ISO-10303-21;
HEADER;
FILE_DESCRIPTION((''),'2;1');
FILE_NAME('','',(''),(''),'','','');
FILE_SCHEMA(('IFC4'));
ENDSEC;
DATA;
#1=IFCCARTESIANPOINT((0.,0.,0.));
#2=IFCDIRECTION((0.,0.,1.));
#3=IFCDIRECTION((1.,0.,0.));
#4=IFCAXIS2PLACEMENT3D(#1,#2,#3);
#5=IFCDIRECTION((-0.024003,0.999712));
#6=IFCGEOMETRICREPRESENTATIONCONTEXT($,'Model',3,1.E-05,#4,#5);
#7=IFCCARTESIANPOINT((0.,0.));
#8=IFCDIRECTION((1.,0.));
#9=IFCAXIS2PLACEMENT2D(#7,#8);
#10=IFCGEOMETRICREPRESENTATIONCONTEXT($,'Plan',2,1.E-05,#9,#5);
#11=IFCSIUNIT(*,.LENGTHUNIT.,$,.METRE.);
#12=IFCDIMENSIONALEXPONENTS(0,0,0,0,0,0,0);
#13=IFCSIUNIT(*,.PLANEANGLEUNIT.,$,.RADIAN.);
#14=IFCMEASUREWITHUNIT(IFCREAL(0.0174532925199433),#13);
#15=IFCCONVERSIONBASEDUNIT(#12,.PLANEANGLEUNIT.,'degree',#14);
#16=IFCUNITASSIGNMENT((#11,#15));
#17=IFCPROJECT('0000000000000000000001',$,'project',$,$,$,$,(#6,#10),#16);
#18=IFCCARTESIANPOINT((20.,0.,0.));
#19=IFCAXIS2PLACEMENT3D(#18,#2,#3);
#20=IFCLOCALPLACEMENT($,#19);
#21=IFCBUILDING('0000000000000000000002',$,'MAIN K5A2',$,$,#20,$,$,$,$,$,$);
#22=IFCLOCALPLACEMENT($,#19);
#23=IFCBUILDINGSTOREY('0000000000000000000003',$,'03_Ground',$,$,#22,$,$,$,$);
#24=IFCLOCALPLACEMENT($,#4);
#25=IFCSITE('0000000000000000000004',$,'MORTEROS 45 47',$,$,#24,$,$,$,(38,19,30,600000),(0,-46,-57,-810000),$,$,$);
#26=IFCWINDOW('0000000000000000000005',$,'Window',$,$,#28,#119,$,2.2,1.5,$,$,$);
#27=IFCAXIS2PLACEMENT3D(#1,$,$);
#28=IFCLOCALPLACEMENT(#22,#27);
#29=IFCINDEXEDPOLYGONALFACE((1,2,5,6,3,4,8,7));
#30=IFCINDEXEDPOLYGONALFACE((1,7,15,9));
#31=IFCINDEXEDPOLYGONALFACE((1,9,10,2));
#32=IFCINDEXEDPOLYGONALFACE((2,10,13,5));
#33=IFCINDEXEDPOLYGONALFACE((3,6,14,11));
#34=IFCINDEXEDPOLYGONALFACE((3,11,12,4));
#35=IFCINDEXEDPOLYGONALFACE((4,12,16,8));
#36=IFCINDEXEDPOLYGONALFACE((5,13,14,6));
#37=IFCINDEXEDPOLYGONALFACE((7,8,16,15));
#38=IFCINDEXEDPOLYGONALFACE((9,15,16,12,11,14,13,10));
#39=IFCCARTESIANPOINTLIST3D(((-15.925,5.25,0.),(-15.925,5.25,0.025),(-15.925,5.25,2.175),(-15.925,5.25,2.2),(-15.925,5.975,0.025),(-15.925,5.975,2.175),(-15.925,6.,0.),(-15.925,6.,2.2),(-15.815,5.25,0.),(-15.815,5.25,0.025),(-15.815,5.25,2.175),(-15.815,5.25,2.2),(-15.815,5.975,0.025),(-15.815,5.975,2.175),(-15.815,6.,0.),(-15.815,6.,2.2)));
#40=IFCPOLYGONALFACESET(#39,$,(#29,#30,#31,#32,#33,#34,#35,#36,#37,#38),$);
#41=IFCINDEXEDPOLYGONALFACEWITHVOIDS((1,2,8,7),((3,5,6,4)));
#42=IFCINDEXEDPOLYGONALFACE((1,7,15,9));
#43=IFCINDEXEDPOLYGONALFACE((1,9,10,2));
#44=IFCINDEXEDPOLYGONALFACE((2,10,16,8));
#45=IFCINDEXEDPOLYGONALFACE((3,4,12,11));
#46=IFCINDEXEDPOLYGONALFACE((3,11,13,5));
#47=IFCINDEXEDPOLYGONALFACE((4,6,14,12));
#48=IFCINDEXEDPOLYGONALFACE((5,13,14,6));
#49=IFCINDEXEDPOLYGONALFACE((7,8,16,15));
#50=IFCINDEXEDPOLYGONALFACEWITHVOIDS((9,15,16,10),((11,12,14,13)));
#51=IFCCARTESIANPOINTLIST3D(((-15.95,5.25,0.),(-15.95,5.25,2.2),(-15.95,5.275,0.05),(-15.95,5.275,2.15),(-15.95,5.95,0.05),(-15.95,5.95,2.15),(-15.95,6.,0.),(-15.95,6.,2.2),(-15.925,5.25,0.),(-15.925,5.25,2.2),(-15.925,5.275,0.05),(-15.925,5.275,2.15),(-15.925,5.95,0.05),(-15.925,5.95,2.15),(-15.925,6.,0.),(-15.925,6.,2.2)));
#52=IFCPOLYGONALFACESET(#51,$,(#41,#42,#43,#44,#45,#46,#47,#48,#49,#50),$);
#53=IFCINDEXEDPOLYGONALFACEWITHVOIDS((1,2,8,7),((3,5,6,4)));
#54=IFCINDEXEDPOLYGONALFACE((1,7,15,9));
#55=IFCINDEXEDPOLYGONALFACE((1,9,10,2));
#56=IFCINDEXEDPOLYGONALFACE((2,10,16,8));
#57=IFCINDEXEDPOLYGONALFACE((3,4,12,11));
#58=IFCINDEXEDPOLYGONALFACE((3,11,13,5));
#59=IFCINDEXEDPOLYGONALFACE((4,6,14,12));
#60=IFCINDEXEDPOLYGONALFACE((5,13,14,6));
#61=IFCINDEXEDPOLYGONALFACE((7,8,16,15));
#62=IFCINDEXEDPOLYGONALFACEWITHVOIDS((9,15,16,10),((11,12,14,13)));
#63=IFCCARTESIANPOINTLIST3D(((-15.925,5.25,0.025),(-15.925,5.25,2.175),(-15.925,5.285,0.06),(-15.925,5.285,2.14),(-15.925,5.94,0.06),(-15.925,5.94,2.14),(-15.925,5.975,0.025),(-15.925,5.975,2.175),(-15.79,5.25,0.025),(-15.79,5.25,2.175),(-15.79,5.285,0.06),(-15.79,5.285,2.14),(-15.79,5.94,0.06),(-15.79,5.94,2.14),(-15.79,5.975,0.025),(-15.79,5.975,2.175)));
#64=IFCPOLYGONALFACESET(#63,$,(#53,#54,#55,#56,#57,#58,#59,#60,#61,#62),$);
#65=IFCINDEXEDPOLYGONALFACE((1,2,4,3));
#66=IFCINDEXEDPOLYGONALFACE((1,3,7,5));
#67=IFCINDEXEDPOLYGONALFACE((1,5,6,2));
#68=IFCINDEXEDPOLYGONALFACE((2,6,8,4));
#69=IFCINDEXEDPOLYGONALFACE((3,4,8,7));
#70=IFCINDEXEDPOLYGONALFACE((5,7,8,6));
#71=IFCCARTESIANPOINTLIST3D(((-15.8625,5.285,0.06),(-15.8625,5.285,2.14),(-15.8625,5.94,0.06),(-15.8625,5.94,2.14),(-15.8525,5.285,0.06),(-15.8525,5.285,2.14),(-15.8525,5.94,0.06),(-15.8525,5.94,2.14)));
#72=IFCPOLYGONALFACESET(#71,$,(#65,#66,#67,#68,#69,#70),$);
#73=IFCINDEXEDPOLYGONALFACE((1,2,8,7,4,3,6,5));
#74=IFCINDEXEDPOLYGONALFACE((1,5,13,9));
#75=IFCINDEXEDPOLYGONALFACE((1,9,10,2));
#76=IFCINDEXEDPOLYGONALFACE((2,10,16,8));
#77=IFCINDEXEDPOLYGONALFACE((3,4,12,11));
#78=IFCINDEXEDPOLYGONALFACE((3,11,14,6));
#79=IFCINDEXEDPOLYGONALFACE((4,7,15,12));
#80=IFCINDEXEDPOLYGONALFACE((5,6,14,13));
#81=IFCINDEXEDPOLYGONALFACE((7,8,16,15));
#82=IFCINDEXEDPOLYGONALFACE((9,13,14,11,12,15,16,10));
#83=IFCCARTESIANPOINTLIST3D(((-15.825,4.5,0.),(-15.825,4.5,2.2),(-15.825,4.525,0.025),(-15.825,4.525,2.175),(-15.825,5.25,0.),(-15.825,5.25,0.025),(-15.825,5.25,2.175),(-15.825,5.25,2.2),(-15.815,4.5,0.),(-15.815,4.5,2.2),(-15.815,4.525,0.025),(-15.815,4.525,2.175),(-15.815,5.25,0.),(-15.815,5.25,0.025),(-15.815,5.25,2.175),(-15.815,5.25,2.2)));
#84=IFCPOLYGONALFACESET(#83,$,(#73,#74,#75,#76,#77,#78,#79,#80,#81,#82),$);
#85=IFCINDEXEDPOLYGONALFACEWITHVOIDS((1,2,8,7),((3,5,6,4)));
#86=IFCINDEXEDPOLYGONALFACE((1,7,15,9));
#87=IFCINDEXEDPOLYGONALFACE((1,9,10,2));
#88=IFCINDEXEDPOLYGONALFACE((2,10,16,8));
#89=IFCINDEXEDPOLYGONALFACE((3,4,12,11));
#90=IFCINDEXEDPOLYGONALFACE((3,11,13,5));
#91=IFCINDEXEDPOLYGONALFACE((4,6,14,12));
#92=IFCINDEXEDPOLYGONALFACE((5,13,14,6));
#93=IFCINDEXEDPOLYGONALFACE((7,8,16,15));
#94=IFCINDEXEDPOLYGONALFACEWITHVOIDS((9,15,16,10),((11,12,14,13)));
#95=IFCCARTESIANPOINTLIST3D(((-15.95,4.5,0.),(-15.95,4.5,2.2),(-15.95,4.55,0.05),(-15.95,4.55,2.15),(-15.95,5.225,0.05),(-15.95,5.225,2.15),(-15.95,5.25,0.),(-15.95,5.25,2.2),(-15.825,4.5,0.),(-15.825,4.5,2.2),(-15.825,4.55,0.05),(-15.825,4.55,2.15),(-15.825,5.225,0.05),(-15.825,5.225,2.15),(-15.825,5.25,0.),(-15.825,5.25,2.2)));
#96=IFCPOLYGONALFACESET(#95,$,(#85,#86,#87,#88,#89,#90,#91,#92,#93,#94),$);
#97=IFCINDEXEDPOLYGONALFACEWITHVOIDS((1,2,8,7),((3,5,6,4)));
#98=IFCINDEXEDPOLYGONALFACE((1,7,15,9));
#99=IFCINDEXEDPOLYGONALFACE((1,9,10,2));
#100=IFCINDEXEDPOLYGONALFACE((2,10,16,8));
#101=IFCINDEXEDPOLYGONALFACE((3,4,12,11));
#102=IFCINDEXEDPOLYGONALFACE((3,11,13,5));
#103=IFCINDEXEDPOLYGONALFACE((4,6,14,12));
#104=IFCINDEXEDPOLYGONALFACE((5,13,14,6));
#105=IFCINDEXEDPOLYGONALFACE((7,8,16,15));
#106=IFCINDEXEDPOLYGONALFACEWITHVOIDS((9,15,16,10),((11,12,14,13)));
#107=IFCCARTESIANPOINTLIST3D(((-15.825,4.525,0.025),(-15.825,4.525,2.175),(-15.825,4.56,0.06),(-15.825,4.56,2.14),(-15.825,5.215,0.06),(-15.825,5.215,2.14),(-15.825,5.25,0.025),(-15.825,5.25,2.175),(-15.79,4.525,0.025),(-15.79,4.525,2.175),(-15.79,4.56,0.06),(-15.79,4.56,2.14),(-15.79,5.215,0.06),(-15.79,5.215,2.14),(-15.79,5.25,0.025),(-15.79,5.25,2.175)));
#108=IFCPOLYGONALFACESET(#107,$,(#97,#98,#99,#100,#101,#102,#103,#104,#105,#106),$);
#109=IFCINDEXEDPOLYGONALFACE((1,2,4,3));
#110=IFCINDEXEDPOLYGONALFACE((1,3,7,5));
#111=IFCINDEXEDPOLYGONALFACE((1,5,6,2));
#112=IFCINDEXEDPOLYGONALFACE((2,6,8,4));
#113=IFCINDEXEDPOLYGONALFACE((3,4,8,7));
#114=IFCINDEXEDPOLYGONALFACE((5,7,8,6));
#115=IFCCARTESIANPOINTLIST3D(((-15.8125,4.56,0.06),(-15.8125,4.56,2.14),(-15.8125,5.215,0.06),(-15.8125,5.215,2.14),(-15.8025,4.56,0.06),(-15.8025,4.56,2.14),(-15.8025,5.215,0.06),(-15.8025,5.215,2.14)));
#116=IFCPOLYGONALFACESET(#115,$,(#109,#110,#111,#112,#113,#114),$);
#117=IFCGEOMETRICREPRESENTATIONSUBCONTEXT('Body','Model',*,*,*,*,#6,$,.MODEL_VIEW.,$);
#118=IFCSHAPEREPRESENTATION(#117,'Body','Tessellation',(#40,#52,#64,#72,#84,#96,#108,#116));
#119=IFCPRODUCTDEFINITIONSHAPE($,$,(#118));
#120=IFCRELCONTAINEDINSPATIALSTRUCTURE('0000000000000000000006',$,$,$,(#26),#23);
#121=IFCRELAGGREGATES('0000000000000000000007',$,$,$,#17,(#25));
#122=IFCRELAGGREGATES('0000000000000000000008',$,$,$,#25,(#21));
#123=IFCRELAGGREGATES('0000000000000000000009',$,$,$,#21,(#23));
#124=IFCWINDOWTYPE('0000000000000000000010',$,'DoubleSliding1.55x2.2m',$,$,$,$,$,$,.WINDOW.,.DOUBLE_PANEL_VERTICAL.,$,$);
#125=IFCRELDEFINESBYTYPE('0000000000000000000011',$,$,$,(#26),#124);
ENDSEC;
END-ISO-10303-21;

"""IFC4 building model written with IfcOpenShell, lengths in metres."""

from ifc_helpers import new_model, entity, si_unit, converted_unit, direction, frame, origin_with_axes, origin_2d_with_axis, place, context, subcontext, project, spatial, line, indexed_curve, outline, extrude, shape, source, transform, mapped, type_object, element, save


model = new_model("IFC4")

# Units and contexts
model_context = context("Model", 3, precision=1e-05, world=origin_with_axes(), true_north=direction((-0.024003, 0.999712)))
plan_context = context("Plan", 2, precision=1e-05, world=origin_2d_with_axis(), true_north=direction((-0.024003, 0.999712)))
body_context_1 = subcontext(model_context, "Body", "Model", "MODEL_VIEW")
body_context_2 = subcontext(plan_context, "Body", "Plan", "PLAN_VIEW")
ifc_project = project(units=[si_unit("LENGTHUNIT", "METRE"), converted_unit("PLANEANGLEUNIT", "degree", entity("IfcReal", 0.0174532925199433), si_unit("PLANEANGLEUNIT", "RADIAN"), dimensions=[0, 0, 0, 0, 0, 0, 0])], contexts=[model_context, plan_context])

# Site, building, storey
site_placement = place(None, origin_with_axes())
site = spatial("IfcSite", under=ifc_project, at=site_placement, Name="MORTEROS 45 47", RefLatitude=(38, 19, 30, 600000), RefLongitude=(0, -46, -57, -810000))
building_placement = place(None, frame((20.0, 0.0, 0.0), z_axis=(0.0, 0.0, 1.0), x_axis=(1.0, 0.0, 0.0)))
building = spatial("IfcBuilding", under=site, at=building_placement, Name="MAIN K5A2")
storey_placement = place(None, frame((20.0, 0.0, 0.0), z_axis=(0.0, 0.0, 1.0), x_axis=(1.0, 0.0, 0.0)))
storey = spatial("IfcBuildingStorey", under=building, at=storey_placement, Name="03_Ground")

# Window
window_type = type_object("IfcWindowType", Name="DoubleSliding1.55x2.2m", PartitioningType="DOUBLE_PANEL_VERTICAL", PredefinedType="WINDOW")
shared_shape_1 = source(origin_with_axes(), body_context_1, "Body", "SolidModel", [
    extrude(outline(indexed_curve([(0.75, 0.0), (0.0, 0.0), (0.0, 2.2), (0.75, 2.2), (0.75, 2.175), (0.025, 2.175), (0.025, 0.025), (0.75, 0.025)], segments=[line(1, 2, 3, 4, 5, 6, 7, 8, 1)])), frame((0.0, 0.075, 0.0), z_axis=(0.0, -1.0, 0.0), x_axis=(1.0, 0.0, 0.0)), (0.0, 0.0, -1.0), 0.11),
    extrude(outline(indexed_curve([(0.0, 0.0), (0.75, 0.0), (0.75, 2.2), (0.0, 2.2)], segments=[line(1, 2, 3, 4, 1)]), holes=[indexed_curve([(0.05, 0.05), (0.725, 0.05), (0.725, 2.15), (0.05, 2.15)], segments=[line(1, 2, 3, 4, 1)])]), frame((0.0, 0.05, 0.0), z_axis=(0.0, -1.0, 0.0), x_axis=(1.0, 0.0, 0.0)), (0.0, 0.0, -1.0), 0.025),
    extrude(outline(indexed_curve([(0.0, 0.0), (0.725, 0.0), (0.725, 2.15), (0.0, 2.15)], segments=[line(1, 2, 3, 4, 1)]), holes=[indexed_curve([(0.035, 0.035), (0.69, 0.035), (0.69, 2.115), (0.035, 2.115)], segments=[line(1, 2, 3, 4, 1)])]), frame((0.025, 0.075, 0.025), z_axis=(0.0, -1.0, 0.0), x_axis=(1.0, 0.0, 0.0)), (0.0, 0.0, -1.0), 0.135),
    extrude(outline(indexed_curve([(0.035, 0.035), (0.69, 0.035), (0.69, 2.115), (0.035, 2.115)], segments=[line(1, 2, 3, 4, 1)])), frame((0.025, 0.1375, 0.025), z_axis=(0.0, -1.0, 0.0), x_axis=(1.0, 0.0, 0.0)), (0.0, 0.0, -1.0), 0.01),
    extrude(outline(indexed_curve([(0.0, 2.2), (0.75, 2.2), (0.75, 0.0), (0.0, 0.0), (0.0, 0.025), (0.725, 0.025), (0.725, 2.175), (0.0, 2.175)], segments=[line(1, 2, 3, 4, 5, 6, 7, 8, 1)])), frame((0.75, 0.175, 0.0), z_axis=(0.0, -1.0, 0.0), x_axis=(1.0, 0.0, 0.0)), (0.0, 0.0, -1.0), 0.01),
    extrude(outline(indexed_curve([(0.0, 0.0), (0.75, 0.0), (0.75, 2.2), (0.0, 2.2)], segments=[line(1, 2, 3, 4, 1)]), holes=[indexed_curve([(0.025, 0.05), (0.7, 0.05), (0.7, 2.15), (0.025, 2.15)], segments=[line(1, 2, 3, 4, 1)])]), frame((0.75, 0.05, 0.0), z_axis=(0.0, -1.0, 0.0), x_axis=(1.0, 0.0, 0.0)), (0.0, 0.0, -1.0), 0.125),
    extrude(outline(indexed_curve([(0.0, 0.0), (0.725, 0.0), (0.725, 2.15), (0.0, 2.15)], segments=[line(1, 2, 3, 4, 1)]), holes=[indexed_curve([(0.035, 0.035), (0.69, 0.035), (0.69, 2.115), (0.035, 2.115)], segments=[line(1, 2, 3, 4, 1)])]), frame((0.75, 0.175, 0.025), z_axis=(0.0, -1.0, 0.0), x_axis=(1.0, 0.0, 0.0)), (0.0, 0.0, -1.0), 0.035),
    extrude(outline(indexed_curve([(0.035, 0.035), (0.69, 0.035), (0.69, 2.115), (0.035, 2.115)], segments=[line(1, 2, 3, 4, 1)])), frame((0.75, 0.1875, 0.025), z_axis=(0.0, -1.0, 0.0), x_axis=(1.0, 0.0, 0.0)), (0.0, 0.0, -1.0), 0.01),
])
shared_shape_2 = source(origin_with_axes(), body_context_2, "Body", "Curve2D", [
    entity("IfcIndexedPolyCurve", entity("IfcCartesianPointList2D", [[0.05, 0.05], [0.725, 0.05]])),
    entity("IfcIndexedPolyCurve", entity("IfcCartesianPointList2D", [[0.0, 0.185], [0.025, 0.185], [0.025, 0.075], [0.05, 0.075], [0.05, 0.05], [0.0, 0.05]]), [entity("IfcLineIndex", [1, 2, 3, 4, 5, 6, 1])]),
    entity("IfcIndexedPolyCurve", entity("IfcCartesianPointList2D", [[0.75, 0.185], [0.75, 0.185], [0.75, 0.075], [0.725, 0.075], [0.725, 0.05], [0.75, 0.05]])),
    entity("IfcIndexedPolyCurve", entity("IfcCartesianPointList2D", [[0.025, 0.075], [0.06, 0.075], [0.06, 0.21], [0.025, 0.21]]), [entity("IfcLineIndex", [1, 2, 3, 4, 1])]),
    entity("IfcIndexedPolyCurve", entity("IfcCartesianPointList2D", [[0.75, 0.075], [0.715, 0.075], [0.715, 0.21], [0.75, 0.21]]), [entity("IfcLineIndex", [1, 2, 3, 4, 1])]),
    entity("IfcIndexedPolyCurve", entity("IfcCartesianPointList2D", [[0.06, 0.075], [0.715, 0.075]])),
    entity("IfcIndexedPolyCurve", entity("IfcCartesianPointList2D", [[0.06, 0.21], [0.715, 0.21]])),
    entity("IfcIndexedPolyCurve", entity("IfcCartesianPointList2D", [[0.06, 0.1425], [0.715, 0.1425]])),
    entity("IfcIndexedPolyCurve", entity("IfcCartesianPointList2D", [[0.775, 0.05], [1.45, 0.05]])),
    entity("IfcIndexedPolyCurve", entity("IfcCartesianPointList2D", [[0.75, 0.185], [0.75, 0.185], [0.75, 0.175], [0.775, 0.175], [0.775, 0.05], [0.75, 0.05]])),
    entity("IfcIndexedPolyCurve", entity("IfcCartesianPointList2D", [[1.5, 0.185], [1.475, 0.185], [1.475, 0.175], [1.45, 0.175], [1.45, 0.05], [1.5, 0.05]]), [entity("IfcLineIndex", [1, 2, 3, 4, 5, 6, 1])]),
    entity("IfcIndexedPolyCurve", entity("IfcCartesianPointList2D", [[0.75, 0.175], [0.785, 0.175], [0.785, 0.21], [0.75, 0.21]]), [entity("IfcLineIndex", [1, 2, 3, 4, 1])]),
    entity("IfcIndexedPolyCurve", entity("IfcCartesianPointList2D", [[1.475, 0.175], [1.44, 0.175], [1.44, 0.21], [1.475, 0.21]]), [entity("IfcLineIndex", [1, 2, 3, 4, 1])]),
    entity("IfcIndexedPolyCurve", entity("IfcCartesianPointList2D", [[0.785, 0.175], [1.44, 0.175]])),
    entity("IfcIndexedPolyCurve", entity("IfcCartesianPointList2D", [[0.785, 0.21], [1.44, 0.21]])),
    entity("IfcIndexedPolyCurve", entity("IfcCartesianPointList2D", [[0.785, 0.1925], [1.44, 0.1925]])),
])
window_1_placement = place(None, frame((4.0, 6.0, 0.0), z_axis=(0.0, 0.0, 1.0), x_axis=(0.0, -1.0, 0.0)))
element("IfcWindow", 1, at=window_1_placement, inside=storey, type_object=window_type, Name="Window", OverallHeight=2.2, OverallWidth=1.5, shapes=[
    shape(body_context_1, "Body", "MappedRepresentation", [mapped(shared_shape_1, transform((0.0, 0.0, 0.0), x_axis=(1.0, 0.0, 0.0), y_axis=(0.0, 1.0, 0.0), z_axis=(0.0, 0.0, 1.0), scale=1.0))]),
    shape(body_context_2, "Body", "MappedRepresentation", [mapped(shared_shape_2, transform((0.0, 0.0, 0.0), x_axis=(1.0, 0.0, 0.0), y_axis=(0.0, 1.0, 0.0), z_axis=(0.0, 0.0, 1.0), scale=1.0))]),
])

save(model, "model.ifc")
